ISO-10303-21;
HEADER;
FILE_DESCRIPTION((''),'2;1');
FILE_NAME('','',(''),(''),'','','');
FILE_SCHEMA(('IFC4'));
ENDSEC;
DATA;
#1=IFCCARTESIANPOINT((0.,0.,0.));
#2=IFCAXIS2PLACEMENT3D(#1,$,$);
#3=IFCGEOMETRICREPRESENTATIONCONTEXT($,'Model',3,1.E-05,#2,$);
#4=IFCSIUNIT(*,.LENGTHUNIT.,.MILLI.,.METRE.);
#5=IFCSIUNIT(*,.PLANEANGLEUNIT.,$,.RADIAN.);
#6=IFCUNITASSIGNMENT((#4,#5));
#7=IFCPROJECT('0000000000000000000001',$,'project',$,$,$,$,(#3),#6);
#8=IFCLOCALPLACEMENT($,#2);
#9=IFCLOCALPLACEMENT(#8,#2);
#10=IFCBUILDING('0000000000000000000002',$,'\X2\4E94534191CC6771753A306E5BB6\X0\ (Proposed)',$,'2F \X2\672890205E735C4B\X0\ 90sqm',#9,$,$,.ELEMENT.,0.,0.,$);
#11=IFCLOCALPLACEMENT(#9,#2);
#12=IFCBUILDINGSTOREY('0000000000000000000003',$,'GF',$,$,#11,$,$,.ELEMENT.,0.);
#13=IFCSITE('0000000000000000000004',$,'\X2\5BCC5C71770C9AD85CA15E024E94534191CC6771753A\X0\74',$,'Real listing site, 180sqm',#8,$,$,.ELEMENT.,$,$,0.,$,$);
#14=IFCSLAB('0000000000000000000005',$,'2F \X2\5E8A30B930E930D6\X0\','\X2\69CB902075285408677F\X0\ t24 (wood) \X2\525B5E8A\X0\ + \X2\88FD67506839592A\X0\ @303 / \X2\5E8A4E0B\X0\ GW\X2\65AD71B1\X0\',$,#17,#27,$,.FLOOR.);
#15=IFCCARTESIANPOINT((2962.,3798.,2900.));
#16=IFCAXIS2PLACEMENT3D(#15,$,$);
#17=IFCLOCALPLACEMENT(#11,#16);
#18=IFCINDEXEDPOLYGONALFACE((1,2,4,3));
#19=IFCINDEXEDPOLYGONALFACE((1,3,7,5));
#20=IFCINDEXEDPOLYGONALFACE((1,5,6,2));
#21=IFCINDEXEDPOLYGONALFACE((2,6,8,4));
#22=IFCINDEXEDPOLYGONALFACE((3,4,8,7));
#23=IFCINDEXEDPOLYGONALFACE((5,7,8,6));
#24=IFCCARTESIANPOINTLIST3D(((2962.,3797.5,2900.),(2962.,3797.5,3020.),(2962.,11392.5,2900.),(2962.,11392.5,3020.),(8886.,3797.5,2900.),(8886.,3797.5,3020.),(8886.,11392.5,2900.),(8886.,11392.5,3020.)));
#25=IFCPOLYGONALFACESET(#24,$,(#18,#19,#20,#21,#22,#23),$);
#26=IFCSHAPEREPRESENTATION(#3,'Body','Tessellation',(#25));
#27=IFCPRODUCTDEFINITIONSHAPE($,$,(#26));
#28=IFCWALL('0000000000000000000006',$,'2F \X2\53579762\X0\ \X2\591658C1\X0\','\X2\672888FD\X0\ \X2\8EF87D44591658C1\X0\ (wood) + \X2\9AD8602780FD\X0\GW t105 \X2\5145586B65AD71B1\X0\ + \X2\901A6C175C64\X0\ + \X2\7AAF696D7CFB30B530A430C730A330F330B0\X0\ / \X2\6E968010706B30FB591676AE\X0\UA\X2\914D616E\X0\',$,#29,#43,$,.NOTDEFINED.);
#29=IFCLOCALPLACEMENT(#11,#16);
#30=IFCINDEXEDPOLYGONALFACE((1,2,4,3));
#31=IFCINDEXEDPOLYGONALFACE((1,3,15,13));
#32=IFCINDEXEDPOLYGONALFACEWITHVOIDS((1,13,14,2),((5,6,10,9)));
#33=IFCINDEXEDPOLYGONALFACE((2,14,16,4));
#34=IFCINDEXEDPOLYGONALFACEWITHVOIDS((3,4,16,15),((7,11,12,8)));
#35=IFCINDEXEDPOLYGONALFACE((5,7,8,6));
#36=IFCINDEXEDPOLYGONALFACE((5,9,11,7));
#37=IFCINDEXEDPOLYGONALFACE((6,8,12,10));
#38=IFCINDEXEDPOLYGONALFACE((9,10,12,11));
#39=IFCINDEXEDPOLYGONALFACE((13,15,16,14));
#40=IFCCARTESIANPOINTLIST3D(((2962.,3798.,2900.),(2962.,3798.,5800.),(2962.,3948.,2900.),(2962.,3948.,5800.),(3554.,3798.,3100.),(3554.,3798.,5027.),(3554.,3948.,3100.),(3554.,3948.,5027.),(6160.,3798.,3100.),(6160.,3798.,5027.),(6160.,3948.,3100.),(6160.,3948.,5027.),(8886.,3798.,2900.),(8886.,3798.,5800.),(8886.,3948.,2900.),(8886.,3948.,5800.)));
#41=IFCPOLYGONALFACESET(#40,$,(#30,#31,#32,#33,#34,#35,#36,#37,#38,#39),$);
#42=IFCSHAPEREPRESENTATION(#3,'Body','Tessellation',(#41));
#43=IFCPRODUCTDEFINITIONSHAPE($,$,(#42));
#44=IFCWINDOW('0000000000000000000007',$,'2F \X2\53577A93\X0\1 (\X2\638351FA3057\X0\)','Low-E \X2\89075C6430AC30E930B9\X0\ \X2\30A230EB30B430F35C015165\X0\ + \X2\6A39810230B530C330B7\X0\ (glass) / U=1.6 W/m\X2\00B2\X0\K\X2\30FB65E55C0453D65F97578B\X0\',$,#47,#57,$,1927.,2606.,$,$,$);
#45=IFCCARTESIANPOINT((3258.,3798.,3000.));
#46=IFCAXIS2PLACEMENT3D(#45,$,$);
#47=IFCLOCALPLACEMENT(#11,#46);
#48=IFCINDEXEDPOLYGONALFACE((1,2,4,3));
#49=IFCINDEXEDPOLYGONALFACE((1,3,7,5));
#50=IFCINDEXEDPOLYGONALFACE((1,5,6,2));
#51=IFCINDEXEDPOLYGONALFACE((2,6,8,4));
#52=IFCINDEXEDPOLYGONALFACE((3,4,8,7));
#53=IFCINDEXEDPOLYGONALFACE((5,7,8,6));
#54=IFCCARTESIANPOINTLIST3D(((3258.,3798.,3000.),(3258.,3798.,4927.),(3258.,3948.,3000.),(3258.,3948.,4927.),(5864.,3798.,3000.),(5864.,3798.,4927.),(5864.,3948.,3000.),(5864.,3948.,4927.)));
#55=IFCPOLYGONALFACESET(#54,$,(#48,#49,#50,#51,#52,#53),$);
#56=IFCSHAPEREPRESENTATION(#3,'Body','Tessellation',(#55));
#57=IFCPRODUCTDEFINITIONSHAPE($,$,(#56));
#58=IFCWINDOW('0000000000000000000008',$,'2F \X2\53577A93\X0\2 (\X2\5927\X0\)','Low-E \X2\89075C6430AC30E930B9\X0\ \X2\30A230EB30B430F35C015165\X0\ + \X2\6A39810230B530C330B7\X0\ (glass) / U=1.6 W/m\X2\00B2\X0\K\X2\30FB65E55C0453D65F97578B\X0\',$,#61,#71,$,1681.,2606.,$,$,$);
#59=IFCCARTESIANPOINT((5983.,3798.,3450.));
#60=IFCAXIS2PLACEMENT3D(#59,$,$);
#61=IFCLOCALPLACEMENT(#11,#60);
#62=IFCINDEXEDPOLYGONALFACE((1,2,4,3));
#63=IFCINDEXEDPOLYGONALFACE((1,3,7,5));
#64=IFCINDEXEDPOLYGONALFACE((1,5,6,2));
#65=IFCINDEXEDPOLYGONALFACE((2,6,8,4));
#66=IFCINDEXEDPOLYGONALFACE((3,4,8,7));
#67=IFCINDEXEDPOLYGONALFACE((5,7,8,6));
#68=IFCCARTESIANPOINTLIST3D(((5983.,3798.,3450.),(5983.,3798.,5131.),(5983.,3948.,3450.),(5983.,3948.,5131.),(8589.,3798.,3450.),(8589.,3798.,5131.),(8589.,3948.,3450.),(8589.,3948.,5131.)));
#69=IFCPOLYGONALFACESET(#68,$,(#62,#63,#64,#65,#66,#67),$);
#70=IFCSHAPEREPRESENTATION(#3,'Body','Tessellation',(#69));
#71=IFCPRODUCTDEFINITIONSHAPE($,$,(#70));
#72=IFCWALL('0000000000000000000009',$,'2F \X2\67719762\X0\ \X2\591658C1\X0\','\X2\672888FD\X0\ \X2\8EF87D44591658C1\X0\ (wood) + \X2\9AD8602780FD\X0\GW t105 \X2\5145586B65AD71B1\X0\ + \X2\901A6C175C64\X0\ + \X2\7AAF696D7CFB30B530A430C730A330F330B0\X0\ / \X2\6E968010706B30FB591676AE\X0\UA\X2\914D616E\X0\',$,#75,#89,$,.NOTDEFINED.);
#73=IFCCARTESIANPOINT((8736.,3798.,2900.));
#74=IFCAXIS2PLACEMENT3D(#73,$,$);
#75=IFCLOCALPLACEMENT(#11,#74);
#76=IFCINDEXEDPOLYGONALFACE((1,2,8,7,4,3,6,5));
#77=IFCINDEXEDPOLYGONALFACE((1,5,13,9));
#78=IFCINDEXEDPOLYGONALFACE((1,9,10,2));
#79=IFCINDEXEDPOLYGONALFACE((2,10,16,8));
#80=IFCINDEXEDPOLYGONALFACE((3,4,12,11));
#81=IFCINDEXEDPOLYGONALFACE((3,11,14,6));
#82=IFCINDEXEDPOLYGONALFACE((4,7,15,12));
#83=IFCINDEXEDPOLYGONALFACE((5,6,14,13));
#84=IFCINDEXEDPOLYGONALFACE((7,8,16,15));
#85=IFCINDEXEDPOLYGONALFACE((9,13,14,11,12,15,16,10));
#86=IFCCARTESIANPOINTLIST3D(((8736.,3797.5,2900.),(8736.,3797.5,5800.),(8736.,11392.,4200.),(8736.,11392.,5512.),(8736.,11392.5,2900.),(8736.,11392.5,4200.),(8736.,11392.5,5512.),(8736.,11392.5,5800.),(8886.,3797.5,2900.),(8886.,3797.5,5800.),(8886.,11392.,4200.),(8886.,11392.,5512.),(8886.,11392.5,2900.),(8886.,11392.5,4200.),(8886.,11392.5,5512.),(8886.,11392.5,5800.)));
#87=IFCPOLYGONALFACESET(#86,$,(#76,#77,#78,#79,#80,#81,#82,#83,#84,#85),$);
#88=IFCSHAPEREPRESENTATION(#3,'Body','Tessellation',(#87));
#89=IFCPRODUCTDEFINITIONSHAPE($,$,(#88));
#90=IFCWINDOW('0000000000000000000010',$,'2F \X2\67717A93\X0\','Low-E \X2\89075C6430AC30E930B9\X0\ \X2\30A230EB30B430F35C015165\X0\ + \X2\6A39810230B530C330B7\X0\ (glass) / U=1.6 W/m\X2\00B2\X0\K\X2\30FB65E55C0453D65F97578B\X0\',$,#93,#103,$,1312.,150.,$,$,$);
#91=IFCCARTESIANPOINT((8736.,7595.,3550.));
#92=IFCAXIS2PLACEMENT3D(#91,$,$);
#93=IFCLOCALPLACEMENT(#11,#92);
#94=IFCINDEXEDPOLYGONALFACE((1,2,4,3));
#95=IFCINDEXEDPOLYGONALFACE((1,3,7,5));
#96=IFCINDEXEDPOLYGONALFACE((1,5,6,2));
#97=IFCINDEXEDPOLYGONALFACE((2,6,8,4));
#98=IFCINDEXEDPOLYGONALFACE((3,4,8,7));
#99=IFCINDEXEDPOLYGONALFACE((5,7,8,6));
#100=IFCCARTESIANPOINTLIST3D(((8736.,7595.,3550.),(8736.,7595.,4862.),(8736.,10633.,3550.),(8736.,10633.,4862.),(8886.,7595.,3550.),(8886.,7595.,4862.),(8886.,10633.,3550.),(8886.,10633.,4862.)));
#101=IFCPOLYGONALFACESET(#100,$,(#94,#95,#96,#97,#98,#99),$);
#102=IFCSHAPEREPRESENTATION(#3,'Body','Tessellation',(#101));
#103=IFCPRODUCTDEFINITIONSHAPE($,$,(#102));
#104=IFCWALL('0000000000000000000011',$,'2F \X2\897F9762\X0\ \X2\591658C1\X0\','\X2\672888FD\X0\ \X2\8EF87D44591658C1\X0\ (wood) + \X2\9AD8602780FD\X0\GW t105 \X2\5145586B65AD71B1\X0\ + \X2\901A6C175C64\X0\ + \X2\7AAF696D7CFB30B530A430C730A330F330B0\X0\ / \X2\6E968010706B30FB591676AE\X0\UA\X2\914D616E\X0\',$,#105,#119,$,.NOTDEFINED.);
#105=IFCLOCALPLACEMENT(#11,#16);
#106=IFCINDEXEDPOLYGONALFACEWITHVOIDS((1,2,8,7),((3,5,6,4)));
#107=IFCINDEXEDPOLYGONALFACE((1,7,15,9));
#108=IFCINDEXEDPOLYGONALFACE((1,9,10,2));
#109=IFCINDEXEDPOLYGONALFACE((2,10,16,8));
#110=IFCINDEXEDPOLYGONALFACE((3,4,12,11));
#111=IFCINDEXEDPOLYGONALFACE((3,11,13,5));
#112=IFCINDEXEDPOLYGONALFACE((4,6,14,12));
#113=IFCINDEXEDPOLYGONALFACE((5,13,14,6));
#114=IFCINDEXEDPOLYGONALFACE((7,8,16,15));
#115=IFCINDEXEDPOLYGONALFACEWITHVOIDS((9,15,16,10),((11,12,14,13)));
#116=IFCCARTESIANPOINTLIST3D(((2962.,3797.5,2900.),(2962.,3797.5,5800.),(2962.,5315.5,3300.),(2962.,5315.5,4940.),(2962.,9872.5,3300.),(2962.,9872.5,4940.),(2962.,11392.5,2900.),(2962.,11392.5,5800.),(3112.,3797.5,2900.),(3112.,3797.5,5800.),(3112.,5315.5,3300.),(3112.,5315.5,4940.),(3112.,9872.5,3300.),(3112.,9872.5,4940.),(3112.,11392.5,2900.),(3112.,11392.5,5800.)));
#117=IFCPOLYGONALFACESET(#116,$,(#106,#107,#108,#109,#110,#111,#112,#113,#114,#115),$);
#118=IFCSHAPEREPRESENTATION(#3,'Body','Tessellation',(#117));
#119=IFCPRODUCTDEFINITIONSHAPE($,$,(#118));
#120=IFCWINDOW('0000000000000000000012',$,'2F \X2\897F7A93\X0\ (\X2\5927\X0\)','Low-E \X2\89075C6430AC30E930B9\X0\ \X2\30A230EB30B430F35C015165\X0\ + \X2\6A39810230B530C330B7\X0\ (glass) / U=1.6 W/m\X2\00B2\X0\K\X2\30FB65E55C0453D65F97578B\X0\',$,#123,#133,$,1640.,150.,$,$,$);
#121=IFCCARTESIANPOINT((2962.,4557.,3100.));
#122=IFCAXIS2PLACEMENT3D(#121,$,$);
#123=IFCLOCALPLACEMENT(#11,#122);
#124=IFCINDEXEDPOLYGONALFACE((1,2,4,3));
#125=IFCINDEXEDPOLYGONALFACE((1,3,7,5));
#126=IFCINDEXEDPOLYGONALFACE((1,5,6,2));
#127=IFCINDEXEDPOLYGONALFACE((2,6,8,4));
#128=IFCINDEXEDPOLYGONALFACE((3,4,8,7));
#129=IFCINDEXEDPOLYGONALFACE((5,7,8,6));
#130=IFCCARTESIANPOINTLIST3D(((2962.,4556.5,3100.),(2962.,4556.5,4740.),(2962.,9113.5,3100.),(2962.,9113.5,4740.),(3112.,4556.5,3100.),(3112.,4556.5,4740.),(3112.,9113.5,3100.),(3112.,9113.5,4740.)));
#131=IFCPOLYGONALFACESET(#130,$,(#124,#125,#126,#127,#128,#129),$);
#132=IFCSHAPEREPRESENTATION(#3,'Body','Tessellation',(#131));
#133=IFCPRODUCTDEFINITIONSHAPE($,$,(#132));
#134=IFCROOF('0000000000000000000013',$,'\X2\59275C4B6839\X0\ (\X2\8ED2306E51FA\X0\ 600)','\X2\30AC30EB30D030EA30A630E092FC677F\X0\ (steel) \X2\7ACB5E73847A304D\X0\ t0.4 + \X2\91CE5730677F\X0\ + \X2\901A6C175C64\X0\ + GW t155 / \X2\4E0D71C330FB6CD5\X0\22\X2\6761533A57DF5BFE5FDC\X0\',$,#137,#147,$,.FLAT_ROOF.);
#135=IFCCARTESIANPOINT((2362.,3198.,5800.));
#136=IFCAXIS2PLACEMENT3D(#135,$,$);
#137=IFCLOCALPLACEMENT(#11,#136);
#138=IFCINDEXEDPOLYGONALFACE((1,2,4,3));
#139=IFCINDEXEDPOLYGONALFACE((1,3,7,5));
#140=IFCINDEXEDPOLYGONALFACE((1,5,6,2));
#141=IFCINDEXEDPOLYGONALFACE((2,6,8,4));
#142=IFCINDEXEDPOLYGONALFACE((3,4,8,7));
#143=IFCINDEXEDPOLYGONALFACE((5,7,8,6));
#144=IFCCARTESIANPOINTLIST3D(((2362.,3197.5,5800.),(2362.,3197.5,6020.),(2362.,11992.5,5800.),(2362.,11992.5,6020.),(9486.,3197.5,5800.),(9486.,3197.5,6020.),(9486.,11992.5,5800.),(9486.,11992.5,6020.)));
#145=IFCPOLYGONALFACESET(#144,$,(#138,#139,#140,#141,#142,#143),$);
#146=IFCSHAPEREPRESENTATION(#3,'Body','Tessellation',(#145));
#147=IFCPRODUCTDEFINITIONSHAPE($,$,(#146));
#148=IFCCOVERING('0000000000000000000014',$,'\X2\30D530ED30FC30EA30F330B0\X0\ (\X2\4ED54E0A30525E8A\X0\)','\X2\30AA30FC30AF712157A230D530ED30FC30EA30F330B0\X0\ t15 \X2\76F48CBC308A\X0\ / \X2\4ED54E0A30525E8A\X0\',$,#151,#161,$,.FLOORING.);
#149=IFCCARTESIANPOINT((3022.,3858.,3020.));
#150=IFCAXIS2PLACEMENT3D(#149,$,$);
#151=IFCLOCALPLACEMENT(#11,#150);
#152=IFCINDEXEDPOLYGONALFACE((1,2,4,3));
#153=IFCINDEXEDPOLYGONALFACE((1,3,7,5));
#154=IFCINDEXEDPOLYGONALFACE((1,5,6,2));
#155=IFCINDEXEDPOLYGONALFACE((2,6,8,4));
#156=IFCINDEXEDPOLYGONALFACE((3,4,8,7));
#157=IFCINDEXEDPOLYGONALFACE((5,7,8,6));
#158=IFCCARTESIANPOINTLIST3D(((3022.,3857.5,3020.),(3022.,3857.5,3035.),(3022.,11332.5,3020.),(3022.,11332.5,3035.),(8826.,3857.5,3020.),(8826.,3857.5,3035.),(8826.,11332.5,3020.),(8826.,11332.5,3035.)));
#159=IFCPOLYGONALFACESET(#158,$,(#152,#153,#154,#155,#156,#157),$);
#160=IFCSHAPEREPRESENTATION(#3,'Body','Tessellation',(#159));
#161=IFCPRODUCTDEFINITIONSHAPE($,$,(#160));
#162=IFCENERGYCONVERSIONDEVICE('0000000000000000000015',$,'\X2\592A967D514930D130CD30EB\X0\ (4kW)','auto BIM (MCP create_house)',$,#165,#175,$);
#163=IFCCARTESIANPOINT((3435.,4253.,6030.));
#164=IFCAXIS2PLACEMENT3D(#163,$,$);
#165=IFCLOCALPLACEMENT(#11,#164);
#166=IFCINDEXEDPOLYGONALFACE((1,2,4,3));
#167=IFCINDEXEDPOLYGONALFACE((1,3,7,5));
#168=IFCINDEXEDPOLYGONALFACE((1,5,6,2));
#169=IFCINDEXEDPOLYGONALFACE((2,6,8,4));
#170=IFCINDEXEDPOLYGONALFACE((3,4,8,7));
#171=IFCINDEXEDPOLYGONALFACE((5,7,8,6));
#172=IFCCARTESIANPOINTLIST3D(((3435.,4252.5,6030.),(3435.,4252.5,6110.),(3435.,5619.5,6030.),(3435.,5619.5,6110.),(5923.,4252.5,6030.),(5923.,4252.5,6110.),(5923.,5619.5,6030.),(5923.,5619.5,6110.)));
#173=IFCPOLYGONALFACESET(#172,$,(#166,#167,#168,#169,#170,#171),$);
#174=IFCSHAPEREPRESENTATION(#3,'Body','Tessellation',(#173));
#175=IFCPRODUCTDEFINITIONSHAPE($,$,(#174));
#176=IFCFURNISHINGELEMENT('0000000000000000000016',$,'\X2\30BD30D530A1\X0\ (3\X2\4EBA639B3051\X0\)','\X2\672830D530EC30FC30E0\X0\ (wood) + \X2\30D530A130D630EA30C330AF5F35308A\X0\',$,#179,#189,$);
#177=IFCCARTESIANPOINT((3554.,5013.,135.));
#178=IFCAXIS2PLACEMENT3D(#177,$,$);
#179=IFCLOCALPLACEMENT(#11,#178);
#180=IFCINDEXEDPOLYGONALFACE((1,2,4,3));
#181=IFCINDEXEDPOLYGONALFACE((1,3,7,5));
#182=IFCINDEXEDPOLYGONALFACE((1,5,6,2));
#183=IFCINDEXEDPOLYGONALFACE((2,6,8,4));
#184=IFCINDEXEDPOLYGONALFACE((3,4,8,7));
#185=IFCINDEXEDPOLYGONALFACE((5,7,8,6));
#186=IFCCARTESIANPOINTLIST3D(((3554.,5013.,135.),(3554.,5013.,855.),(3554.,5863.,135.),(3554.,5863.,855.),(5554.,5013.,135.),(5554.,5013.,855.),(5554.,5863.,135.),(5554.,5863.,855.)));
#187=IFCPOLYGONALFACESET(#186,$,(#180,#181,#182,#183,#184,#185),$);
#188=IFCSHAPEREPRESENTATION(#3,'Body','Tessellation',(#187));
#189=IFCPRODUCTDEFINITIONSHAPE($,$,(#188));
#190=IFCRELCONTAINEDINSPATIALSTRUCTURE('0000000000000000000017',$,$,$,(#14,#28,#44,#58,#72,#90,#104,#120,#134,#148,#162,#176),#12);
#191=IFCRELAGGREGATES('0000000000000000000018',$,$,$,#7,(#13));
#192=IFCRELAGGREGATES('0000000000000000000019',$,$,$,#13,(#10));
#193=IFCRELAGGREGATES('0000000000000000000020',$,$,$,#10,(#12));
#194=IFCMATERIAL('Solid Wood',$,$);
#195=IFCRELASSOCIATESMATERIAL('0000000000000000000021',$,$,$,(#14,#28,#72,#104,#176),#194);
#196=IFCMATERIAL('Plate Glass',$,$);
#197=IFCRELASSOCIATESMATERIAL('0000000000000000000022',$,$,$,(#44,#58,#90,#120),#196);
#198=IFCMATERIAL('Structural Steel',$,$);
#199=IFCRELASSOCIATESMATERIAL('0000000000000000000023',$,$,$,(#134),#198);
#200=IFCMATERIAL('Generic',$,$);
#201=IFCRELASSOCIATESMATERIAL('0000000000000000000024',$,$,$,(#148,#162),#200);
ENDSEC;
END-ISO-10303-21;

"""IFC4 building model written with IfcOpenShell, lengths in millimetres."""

from ifc_helpers import new_model, si_unit, frame, frame_2d, origin, place, context, project, spatial, rectangle, extrude, material, element, fill, save


model = new_model("IFC4")

# Units and contexts
model_context = context("Model", 3, precision=1e-05, world=origin())
ifc_project = project(units=[si_unit("LENGTHUNIT", "METRE", prefix="MILLI"), si_unit("PLANEANGLEUNIT", "RADIAN")], contexts=[model_context])

# Site, building, storey
site_placement = place(None, origin())
site = spatial("IfcSite", under=ifc_project, at=site_placement, Name="富山県高岡市五十里東町74", ObjectType="Real listing site, 180sqm", CompositionType="ELEMENT", RefElevation=0.0)
building_placement = place(site_placement, origin())
building = spatial("IfcBuilding", under=site, at=building_placement, Name="五十里東町の家 (Proposed)", ObjectType="2F 木造平屋 90sqm", CompositionType="ELEMENT", ElevationOfRefHeight=0.0, ElevationOfTerrain=0.0)
storey_placement = place(building_placement, origin())
storey = spatial("IfcBuildingStorey", under=building, at=storey_placement, Name="GF", CompositionType="ELEMENT", Elevation=0.0)

# Slab
ifc_material_1 = material(Name="Solid Wood")
slab_placement = place(storey_placement, frame((2962.0, 3798.0, 2900.0)))
element("IfcSlab", 1, at=slab_placement, inside=storey, material=ifc_material_1, Name="2F 床スラブ", Description="構造用合板 t24 (wood) 剛床 + 製材根太 @303 / 床下 GW断熱", PredefinedType="FLOOR", context=model_context, shape_type="SweptSolid", body=[
    extrude(rectangle(XDim=5924.0, YDim=7595.0, at=frame_2d((2962.0, 3797.0))), frame((2962.0, 3798.0, 2900.0)), (0.0, 0.0, 1.0), 120.0),
])

# Wall, openings, windows
wall_1_placement = place(storey_placement, frame((2962.0, 3798.0, 2900.0)))
wall_1 = element("IfcWall", 2, at=wall_1_placement, inside=storey, material=ifc_material_1, Name="2F 南面 外壁", Description="木製 軸組外壁 (wood) + 高性能GW t105 充填断熱 + 通気層 + 窯業系サイディング / 準耐火・外皮UA配慮", PredefinedType="NOTDEFINED", context=model_context, shape_type="SweptSolid", body=[
    extrude(rectangle(XDim=5924.0, YDim=150.0, at=frame_2d((2962.0, 75.0))), frame((2962.0, 3798.0, 2900.0)), (0.0, 0.0, 1.0), 2900.0),
])
opening_1_placement = place(storey_placement, frame((3258.0, 3798.0, 3000.0)))
opening_1 = element("IfcOpeningElement", 3, at=opening_1_placement, cuts=wall_1, PredefinedType="NOTDEFINED", context=model_context, shape_type="SweptSolid", body=[
    extrude(rectangle(XDim=2606.0, YDim=150.0, at=frame_2d((1303.0, 75.0))), frame((3258.0, 3798.0, 3000.0)), (0.0, 0.0, 1.0), 1927.0),
])
opening_2_placement = place(storey_placement, frame((5983.0, 3798.0, 3450.0)))
opening_2 = element("IfcOpeningElement", 4, at=opening_2_placement, cuts=wall_1, PredefinedType="NOTDEFINED", context=model_context, shape_type="SweptSolid", body=[
    extrude(rectangle(XDim=2606.0, YDim=150.0, at=frame_2d((1303.0, 75.0))), frame((5983.0, 3798.0, 3450.0)), (0.0, 0.0, 1.0), 1681.0),
])
ifc_material_2 = material(Name="Plate Glass")
window_1_placement = place(storey_placement, frame((3258.0, 3798.0, 3000.0)))
window_1 = element("IfcWindow", 5, at=window_1_placement, inside=storey, material=ifc_material_2, Name="2F 南窓1 (掃出し)", Description="Low-E 複層ガラス アルゴン封入 + 樹脂サッシ (glass) / U=1.6 W/m²K・日射取得型", OverallHeight=1927.0, OverallWidth=2606.0, context=model_context, shape_type="SweptSolid", body=[
    extrude(rectangle(XDim=2606.0, YDim=150.0, at=frame_2d((1303.0, 75.0))), frame((3258.0, 3798.0, 3000.0)), (0.0, 0.0, 1.0), 1927.0),
])
fill(opening_1, window_1)
window_2_placement = place(storey_placement, frame((5983.0, 3798.0, 3450.0)))
window_2 = element("IfcWindow", 6, at=window_2_placement, inside=storey, material=ifc_material_2, Name="2F 南窓2 (大)", Description="Low-E 複層ガラス アルゴン封入 + 樹脂サッシ (glass) / U=1.6 W/m²K・日射取得型", OverallHeight=1681.0, OverallWidth=2606.0, context=model_context, shape_type="SweptSolid", body=[
    extrude(rectangle(XDim=2606.0, YDim=150.0, at=frame_2d((1303.0, 75.0))), frame((5983.0, 3798.0, 3450.0)), (0.0, 0.0, 1.0), 1681.0),
])
fill(opening_2, window_2)

# Walls, openings, windows
wall_2_placement = place(storey_placement, frame((8736.0, 3798.0, 2900.0)))
wall_2 = element("IfcWall", 7, at=wall_2_placement, inside=storey, material=ifc_material_1, Name="2F 東面 外壁", Description="木製 軸組外壁 (wood) + 高性能GW t105 充填断熱 + 通気層 + 窯業系サイディング / 準耐火・外皮UA配慮", PredefinedType="NOTDEFINED", context=model_context, shape_type="SweptSolid", body=[
    extrude(rectangle(XDim=150.0, YDim=7595.0, at=frame_2d((75.0, 3797.0))), frame((8736.0, 3798.0, 2900.0)), (0.0, 0.0, 1.0), 2900.0),
])
opening_3_placement = place(storey_placement, frame((8736.0, 7595.0, 3550.0)))
opening_3 = element("IfcOpeningElement", 8, at=opening_3_placement, cuts=wall_2, PredefinedType="NOTDEFINED", context=model_context, shape_type="SweptSolid", body=[
    extrude(rectangle(XDim=150.0, YDim=3038.0, at=frame_2d((75.0, 1519.0))), frame((8736.0, 7595.0, 3550.0)), (0.0, 0.0, 1.0), 1312.0),
])
window_3_placement = place(storey_placement, frame((8736.0, 7595.0, 3550.0)))
window_3 = element("IfcWindow", 9, at=window_3_placement, inside=storey, material=ifc_material_2, Name="2F 東窓", Description="Low-E 複層ガラス アルゴン封入 + 樹脂サッシ (glass) / U=1.6 W/m²K・日射取得型", OverallHeight=1312.0, OverallWidth=150.0, context=model_context, shape_type="SweptSolid", body=[
    extrude(rectangle(XDim=150.0, YDim=3038.0, at=frame_2d((75.0, 1519.0))), frame((8736.0, 7595.0, 3550.0)), (0.0, 0.0, 1.0), 1312.0),
])
fill(opening_3, window_3)
wall_3_placement = place(storey_placement, frame((2962.0, 3798.0, 2900.0)))
wall_3 = element("IfcWall", 10, at=wall_3_placement, inside=storey, material=ifc_material_1, Name="2F 西面 外壁", Description="木製 軸組外壁 (wood) + 高性能GW t105 充填断熱 + 通気層 + 窯業系サイディング / 準耐火・外皮UA配慮", PredefinedType="NOTDEFINED", context=model_context, shape_type="SweptSolid", body=[
    extrude(rectangle(XDim=150.0, YDim=7595.0, at=frame_2d((75.0, 3797.0))), frame((2962.0, 3798.0, 2900.0)), (0.0, 0.0, 1.0), 2900.0),
])
opening_4_placement = place(storey_placement, frame((2962.0, 4557.0, 3100.0)))
opening_4 = element("IfcOpeningElement", 11, at=opening_4_placement, cuts=wall_3, PredefinedType="NOTDEFINED", context=model_context, shape_type="SweptSolid", body=[
    extrude(rectangle(XDim=150.0, YDim=4557.0, at=frame_2d((75.0, 2278.0))), frame((2962.0, 4557.0, 3100.0)), (0.0, 0.0, 1.0), 1640.0),
])
window_4_placement = place(storey_placement, frame((2962.0, 4557.0, 3100.0)))
window_4 = element("IfcWindow", 12, at=window_4_placement, inside=storey, material=ifc_material_2, Name="2F 西窓 (大)", Description="Low-E 複層ガラス アルゴン封入 + 樹脂サッシ (glass) / U=1.6 W/m²K・日射取得型", OverallHeight=1640.0, OverallWidth=150.0, context=model_context, shape_type="SweptSolid", body=[
    extrude(rectangle(XDim=150.0, YDim=4557.0, at=frame_2d((75.0, 2278.0))), frame((2962.0, 4557.0, 3100.0)), (0.0, 0.0, 1.0), 1640.0),
])
fill(opening_4, window_4)

# Roof
ifc_material_3 = material(Name="Structural Steel")
roof_placement = place(storey_placement, frame((2362.0, 3198.0, 5800.0)))
element("IfcRoof", 13, at=roof_placement, inside=storey, material=ifc_material_3, Name="大屋根 (軒の出 600)", Description="ガルバリウム鋼板 (steel) 立平葺き t0.4 + 野地板 + 通気層 + GW t155 / 不燃・法22条区域対応", PredefinedType="FLAT_ROOF", context=model_context, shape_type="SweptSolid", body=[
    extrude(rectangle(XDim=7124.0, YDim=8795.0, at=frame_2d((3562.0, 4397.0))), frame((2362.0, 3198.0, 5800.0)), (0.0, 0.0, 1.0), 220.0),
])

# Covering
ifc_material_4 = material(Name="Generic")
covering_placement = place(storey_placement, frame((3022.0, 3858.0, 3020.0)))
element("IfcCovering", 14, at=covering_placement, inside=storey, material=ifc_material_4, Name="フローリング (仕上げ床)", Description="オーク無垢フローリング t15 直貼り / 仕上げ床", PredefinedType="FLOORING", context=model_context, shape_type="SweptSolid", body=[
    extrude(rectangle(XDim=5804.0, YDim=7475.0, at=frame_2d((2902.0, 3737.0))), frame((3022.0, 3858.0, 3020.0)), (0.0, 0.0, 1.0), 15.0),
])

# Energy conversion device
energy_conversion_device_placement = place(storey_placement, frame((3435.0, 4253.0, 6030.0)))
element("IfcEnergyConversionDevice", 15, at=energy_conversion_device_placement, inside=storey, material=ifc_material_4, Name="太陽光パネル (4kW)", Description="auto BIM (MCP create_house)", context=model_context, shape_type="SweptSolid", body=[
    extrude(rectangle(XDim=2488.0, YDim=1367.0, at=frame_2d((1244.0, 683.0))), frame((3435.0, 4253.0, 6030.0)), (0.0, 0.0, 1.0), 80.0),
])

# Furnishing element
furnishing_1_placement = place(storey_placement, frame((3554.0, 5013.0, 135.0)))
element("IfcFurnishingElement", 16, at=furnishing_1_placement, inside=storey, material=ifc_material_1, Name="ソファ (3人掛け)", Description="木フレーム (wood) + ファブリック張り", context=model_context, shape_type="SweptSolid", body=[
    extrude(rectangle(XDim=2000.0, YDim=850.0, at=frame_2d((1000.0, 425.0))), frame((3554.0, 5013.0, 135.0)), (0.0, 0.0, 1.0), 720.0),
])

save(model, "model.ifc")
